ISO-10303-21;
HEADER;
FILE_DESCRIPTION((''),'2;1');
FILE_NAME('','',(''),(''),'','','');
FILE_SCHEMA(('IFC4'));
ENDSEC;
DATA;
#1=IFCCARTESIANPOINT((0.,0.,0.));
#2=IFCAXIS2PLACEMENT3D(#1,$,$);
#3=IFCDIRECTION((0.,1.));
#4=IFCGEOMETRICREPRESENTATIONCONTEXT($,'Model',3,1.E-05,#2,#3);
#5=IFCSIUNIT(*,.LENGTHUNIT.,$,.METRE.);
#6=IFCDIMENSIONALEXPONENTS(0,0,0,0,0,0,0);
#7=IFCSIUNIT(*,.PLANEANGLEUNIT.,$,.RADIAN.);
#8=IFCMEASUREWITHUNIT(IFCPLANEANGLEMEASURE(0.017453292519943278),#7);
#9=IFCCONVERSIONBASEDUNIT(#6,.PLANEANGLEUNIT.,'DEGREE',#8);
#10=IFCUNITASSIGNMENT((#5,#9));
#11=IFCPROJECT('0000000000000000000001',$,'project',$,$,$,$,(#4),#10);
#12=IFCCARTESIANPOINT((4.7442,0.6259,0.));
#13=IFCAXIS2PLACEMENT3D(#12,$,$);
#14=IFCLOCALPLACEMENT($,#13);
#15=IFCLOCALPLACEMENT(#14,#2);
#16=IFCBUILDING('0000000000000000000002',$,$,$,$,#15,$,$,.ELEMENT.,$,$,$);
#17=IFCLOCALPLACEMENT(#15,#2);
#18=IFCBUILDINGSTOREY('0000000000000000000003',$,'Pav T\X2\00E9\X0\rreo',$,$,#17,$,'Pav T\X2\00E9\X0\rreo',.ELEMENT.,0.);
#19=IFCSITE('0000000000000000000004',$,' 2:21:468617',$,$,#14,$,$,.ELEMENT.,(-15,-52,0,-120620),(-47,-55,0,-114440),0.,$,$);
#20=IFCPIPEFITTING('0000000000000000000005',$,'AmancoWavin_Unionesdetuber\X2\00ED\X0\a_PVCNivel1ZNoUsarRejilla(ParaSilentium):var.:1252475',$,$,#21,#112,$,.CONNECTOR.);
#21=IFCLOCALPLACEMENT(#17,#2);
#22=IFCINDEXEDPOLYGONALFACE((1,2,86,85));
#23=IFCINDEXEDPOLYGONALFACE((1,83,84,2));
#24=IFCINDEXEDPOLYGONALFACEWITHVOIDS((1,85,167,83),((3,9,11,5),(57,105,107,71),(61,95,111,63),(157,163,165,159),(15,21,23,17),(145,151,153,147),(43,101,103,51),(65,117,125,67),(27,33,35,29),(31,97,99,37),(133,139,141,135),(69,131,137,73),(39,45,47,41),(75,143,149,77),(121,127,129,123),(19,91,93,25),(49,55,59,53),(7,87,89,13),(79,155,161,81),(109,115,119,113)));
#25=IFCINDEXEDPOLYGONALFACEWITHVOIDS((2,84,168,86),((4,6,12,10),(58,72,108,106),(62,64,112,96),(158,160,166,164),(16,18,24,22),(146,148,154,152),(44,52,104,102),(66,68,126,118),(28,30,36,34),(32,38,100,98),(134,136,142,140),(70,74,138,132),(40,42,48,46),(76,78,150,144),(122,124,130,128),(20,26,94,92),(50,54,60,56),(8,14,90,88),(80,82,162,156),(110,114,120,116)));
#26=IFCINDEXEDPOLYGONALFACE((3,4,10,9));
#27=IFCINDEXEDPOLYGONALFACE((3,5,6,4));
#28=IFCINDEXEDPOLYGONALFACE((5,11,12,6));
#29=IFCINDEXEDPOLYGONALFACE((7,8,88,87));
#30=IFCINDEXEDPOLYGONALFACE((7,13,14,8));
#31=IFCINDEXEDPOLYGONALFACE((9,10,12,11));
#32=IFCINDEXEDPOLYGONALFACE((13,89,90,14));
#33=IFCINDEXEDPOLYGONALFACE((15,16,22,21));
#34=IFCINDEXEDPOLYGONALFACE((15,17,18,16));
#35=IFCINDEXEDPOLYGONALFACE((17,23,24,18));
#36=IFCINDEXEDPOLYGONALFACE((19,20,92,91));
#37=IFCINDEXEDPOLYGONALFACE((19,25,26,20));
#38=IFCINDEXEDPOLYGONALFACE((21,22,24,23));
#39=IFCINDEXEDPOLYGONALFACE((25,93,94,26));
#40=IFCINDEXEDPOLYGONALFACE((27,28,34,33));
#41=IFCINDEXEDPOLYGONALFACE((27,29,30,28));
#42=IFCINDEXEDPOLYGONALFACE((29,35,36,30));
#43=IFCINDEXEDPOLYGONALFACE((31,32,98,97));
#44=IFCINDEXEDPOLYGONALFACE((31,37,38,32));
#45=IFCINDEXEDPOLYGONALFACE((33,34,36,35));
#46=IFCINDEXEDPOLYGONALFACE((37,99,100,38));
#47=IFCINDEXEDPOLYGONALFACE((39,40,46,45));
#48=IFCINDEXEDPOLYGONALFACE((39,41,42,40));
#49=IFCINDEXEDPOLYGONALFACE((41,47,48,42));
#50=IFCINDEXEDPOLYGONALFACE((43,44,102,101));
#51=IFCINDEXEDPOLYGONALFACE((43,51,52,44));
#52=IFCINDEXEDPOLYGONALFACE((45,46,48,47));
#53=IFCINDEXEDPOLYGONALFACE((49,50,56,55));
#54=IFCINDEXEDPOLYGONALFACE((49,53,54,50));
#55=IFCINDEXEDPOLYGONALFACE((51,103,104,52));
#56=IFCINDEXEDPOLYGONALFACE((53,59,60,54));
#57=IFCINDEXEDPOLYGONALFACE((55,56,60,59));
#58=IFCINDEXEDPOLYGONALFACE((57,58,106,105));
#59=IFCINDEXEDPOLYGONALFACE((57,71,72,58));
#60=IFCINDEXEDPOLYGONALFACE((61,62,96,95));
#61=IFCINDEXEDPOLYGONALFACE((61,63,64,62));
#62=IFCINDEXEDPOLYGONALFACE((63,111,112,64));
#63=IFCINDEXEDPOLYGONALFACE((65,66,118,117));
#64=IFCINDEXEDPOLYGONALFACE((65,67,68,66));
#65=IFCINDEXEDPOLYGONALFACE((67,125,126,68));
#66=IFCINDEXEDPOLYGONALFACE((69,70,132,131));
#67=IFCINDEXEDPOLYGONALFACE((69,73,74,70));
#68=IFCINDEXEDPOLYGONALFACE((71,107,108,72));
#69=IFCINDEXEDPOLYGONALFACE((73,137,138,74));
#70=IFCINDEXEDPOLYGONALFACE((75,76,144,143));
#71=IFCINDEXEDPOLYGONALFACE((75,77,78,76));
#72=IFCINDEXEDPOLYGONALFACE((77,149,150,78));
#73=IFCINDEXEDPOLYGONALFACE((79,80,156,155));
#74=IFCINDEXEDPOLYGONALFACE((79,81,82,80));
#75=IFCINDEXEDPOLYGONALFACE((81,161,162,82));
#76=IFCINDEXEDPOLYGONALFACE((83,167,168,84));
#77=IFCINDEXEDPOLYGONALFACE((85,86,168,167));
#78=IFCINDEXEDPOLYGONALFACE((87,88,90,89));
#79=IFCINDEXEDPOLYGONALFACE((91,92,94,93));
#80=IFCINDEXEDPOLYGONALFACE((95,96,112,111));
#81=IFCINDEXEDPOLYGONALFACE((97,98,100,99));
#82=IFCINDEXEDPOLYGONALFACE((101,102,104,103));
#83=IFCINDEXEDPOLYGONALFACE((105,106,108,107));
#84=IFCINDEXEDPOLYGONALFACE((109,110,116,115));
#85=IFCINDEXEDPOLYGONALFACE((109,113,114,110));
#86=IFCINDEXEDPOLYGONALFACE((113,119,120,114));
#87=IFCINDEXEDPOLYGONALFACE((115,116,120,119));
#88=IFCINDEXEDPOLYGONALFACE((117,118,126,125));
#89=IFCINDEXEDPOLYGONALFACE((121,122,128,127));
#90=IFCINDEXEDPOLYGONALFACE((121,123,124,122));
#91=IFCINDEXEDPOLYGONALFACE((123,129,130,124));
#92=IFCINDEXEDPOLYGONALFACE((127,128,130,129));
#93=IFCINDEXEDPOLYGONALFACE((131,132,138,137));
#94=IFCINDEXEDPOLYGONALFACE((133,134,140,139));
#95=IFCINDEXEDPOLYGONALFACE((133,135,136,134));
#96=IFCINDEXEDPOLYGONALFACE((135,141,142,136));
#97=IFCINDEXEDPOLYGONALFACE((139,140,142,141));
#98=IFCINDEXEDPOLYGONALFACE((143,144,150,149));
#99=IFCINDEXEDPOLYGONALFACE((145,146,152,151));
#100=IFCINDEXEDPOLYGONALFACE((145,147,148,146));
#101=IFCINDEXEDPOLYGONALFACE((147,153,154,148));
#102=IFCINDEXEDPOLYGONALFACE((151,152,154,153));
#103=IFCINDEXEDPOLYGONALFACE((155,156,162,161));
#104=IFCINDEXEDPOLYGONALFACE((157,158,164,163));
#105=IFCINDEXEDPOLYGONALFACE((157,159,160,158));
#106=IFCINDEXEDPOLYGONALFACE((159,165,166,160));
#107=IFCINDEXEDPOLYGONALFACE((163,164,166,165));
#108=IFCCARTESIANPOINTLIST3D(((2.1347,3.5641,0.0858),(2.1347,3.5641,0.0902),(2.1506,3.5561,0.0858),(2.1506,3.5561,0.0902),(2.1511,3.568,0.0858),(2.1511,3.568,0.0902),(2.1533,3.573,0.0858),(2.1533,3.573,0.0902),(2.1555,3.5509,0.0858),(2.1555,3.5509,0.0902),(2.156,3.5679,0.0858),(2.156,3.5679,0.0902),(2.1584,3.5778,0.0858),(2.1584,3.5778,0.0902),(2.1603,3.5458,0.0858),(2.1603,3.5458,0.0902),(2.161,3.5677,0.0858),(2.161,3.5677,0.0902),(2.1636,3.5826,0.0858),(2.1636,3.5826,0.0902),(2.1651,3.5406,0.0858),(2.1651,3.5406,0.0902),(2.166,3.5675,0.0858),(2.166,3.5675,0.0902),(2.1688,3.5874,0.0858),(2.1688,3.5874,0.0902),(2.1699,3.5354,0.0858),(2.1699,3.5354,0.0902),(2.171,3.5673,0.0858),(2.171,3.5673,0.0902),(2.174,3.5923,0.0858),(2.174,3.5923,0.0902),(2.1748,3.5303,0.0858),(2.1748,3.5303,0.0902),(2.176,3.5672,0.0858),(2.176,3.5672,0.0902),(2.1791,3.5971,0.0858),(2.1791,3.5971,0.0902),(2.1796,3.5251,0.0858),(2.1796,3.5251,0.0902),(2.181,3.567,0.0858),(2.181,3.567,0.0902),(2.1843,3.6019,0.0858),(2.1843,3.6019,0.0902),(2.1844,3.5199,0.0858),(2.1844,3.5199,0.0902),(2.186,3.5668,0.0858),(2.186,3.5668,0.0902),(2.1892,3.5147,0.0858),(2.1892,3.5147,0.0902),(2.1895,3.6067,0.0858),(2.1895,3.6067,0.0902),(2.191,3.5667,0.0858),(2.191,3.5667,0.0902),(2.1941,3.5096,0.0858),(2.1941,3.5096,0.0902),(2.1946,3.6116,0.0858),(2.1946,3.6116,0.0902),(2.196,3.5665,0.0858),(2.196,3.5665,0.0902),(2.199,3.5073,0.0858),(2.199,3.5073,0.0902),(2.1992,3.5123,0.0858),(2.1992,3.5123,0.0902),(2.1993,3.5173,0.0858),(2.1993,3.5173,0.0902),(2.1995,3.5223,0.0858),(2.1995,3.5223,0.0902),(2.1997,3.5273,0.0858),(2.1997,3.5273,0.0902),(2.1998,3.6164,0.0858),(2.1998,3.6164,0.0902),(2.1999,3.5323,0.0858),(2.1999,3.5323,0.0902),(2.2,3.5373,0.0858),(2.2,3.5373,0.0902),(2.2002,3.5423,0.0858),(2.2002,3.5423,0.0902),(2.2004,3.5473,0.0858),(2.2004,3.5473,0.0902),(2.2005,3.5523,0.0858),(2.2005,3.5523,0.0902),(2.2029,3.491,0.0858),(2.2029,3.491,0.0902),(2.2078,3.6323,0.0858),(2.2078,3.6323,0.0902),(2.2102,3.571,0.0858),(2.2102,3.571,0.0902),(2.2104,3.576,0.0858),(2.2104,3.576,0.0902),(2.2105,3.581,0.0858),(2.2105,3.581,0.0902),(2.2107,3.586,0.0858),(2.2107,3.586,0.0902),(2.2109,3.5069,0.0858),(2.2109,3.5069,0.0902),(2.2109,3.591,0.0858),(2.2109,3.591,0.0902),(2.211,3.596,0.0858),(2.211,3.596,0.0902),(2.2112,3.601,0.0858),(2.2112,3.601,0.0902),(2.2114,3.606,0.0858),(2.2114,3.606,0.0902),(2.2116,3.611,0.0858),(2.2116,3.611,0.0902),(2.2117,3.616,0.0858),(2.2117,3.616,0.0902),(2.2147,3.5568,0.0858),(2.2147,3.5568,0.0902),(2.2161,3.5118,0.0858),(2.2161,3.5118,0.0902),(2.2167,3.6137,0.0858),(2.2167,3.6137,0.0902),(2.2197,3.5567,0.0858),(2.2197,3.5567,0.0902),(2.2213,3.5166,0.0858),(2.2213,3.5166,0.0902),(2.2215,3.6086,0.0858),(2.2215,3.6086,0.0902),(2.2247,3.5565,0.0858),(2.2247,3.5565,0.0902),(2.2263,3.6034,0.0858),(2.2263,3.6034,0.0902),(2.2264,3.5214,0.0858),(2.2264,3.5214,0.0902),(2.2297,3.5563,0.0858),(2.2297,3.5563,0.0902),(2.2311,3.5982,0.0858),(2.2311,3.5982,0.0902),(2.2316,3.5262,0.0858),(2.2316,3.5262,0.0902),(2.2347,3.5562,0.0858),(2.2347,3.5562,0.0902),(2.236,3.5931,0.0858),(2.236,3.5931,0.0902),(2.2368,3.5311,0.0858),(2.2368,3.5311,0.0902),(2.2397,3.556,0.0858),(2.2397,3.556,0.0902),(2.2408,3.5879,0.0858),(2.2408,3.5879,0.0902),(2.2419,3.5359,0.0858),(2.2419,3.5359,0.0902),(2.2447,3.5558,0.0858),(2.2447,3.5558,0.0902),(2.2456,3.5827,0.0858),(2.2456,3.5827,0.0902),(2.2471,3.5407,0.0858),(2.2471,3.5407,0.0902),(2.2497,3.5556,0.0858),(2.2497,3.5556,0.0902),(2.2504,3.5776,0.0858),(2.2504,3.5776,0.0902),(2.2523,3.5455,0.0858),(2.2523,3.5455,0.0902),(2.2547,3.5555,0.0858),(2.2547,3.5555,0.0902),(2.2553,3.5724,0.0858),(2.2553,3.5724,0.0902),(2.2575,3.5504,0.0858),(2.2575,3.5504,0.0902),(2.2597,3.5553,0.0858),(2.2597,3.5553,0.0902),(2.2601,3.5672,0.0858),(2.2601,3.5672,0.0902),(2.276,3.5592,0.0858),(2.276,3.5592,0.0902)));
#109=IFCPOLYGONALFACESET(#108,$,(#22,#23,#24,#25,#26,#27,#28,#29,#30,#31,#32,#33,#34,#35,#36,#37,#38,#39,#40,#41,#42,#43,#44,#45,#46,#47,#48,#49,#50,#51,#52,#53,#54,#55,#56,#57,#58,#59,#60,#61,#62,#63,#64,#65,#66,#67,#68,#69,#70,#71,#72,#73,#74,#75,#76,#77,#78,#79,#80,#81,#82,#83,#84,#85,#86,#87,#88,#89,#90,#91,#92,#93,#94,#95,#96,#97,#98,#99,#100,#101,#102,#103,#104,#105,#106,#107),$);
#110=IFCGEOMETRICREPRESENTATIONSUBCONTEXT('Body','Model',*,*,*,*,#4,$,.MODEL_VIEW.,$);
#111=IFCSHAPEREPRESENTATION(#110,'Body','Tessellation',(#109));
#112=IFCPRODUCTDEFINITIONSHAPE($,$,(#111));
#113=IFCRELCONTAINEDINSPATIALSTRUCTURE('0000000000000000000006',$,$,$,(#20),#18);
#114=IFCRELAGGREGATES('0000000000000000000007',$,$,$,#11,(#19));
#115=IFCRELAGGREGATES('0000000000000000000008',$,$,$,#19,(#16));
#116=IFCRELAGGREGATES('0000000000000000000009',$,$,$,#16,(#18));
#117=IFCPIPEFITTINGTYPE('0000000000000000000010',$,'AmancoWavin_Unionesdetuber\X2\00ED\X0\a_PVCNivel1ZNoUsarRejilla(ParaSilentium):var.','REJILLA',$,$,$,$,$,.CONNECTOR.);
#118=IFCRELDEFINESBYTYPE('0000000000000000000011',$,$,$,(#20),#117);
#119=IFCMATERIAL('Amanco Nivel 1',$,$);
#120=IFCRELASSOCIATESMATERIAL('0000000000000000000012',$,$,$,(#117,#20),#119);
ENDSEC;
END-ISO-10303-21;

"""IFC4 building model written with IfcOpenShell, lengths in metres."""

from ifc_helpers import new_model, entity, si_unit, converted_unit, direction, frame, origin, place, context, subcontext, project, spatial, indexed_curve, outline, extrude, source, transform, mapped, material, type_object, type_shapes, element, save


model = new_model("IFC4")

# Units and contexts
model_context = context("Model", 3, precision=1e-05, world=origin(), true_north=direction((0.0, 1.0)))
body_context = subcontext(model_context, "Body", "Model", "MODEL_VIEW")
ifc_project = project(units=[si_unit("LENGTHUNIT", "METRE"), converted_unit("PLANEANGLEUNIT", "DEGREE", entity("IfcPlaneAngleMeasure", 0.017453292519943278), si_unit("PLANEANGLEUNIT", "RADIAN"), dimensions=[0, 0, 0, 0, 0, 0, 0])], contexts=[model_context])

# Site, building, storey
site_placement = place(None, frame((4.7442, 0.6259, 0.0)))
site = spatial("IfcSite", under=ifc_project, at=site_placement, Name=" 2:21:468617", CompositionType="ELEMENT", RefLatitude=(-15, -52, 0, -120620), RefLongitude=(-47, -55, 0, -114440), RefElevation=0.0)
building_placement = place(site_placement, origin())
building = spatial("IfcBuilding", under=site, at=building_placement, CompositionType="ELEMENT")
storey_placement = place(building_placement, origin())
storey = spatial("IfcBuildingStorey", under=building, at=storey_placement, Name="Pav Térreo", LongName="Pav Térreo", CompositionType="ELEMENT", Elevation=0.0)

# Pipe fitting
ifc_material = material(Name="Amanco Nivel 1")
pipe_fitting_type = type_object("IfcPipeFittingType", Name="AmancoWavin_Unionesdetubería_PVCNivel1ZNoUsarRejilla(ParaSilentium):var.", Description="REJILLA", PredefinedType="CONNECTOR", material=ifc_material)
shared_shape = source(origin(), body_context, "Body", "SweptSolid", [
    extrude(outline(indexed_curve([(-0.05, -0.05), (0.05, -0.05), (0.05, 0.05), (-0.05, 0.05), (-0.05, -0.05)], self_intersect=False), holes=[indexed_curve([(0.0417, 0.0354), (0.0382, 0.0318), (0.0262, 0.0438), (0.0333, 0.0438), (0.0417, 0.0354)], self_intersect=False), indexed_curve([(0.0346, 0.0283), (0.0311, 0.0247), (0.0121, 0.0438), (0.0191, 0.0438), (0.0346, 0.0283)], self_intersect=False), indexed_curve([(0.0276, 0.0212), (0.024, 0.0177), (-0.0021, 0.0438), (0.005, 0.0438), (0.0276, 0.0212)], self_intersect=False), indexed_curve([(0.0205, 0.0141), (0.017, 0.0106), (-0.0162, 0.0438), (-0.0092, 0.0438), (0.0205, 0.0141)], self_intersect=False), indexed_curve([(0.0134, 0.0071), (0.0099, 0.0035), (-0.0304, 0.0438), (-0.0233, 0.0438), (0.0134, 0.0071)], self_intersect=False), indexed_curve([(-0.0354, 0.0417), (-0.0318, 0.0382), (-0.0438, 0.0262), (-0.0438, 0.0333), (-0.0354, 0.0417)], self_intersect=False), indexed_curve([(-0.0283, 0.0346), (-0.0247, 0.0311), (-0.0438, 0.0121), (-0.0438, 0.0191), (-0.0283, 0.0346)], self_intersect=False), indexed_curve([(-0.0212, 0.0276), (-0.0177, 0.024), (-0.0438, -0.0021), (-0.0438, 0.005), (-0.0212, 0.0276)], self_intersect=False), indexed_curve([(-0.0141, 0.0205), (-0.0106, 0.017), (-0.0438, -0.0162), (-0.0438, -0.0092), (-0.0141, 0.0205)], self_intersect=False), indexed_curve([(-0.0071, 0.0134), (-0.0035, 0.0099), (-0.0438, -0.0304), (-0.0438, -0.0233), (-0.0071, 0.0134)], self_intersect=False), indexed_curve([(-0.0417, -0.0354), (-0.0382, -0.0318), (-0.0262, -0.0438), (-0.0333, -0.0438), (-0.0417, -0.0354)], self_intersect=False), indexed_curve([(-0.0346, -0.0283), (-0.0311, -0.0247), (-0.0121, -0.0438), (-0.0191, -0.0438), (-0.0346, -0.0283)], self_intersect=False), indexed_curve([(-0.0276, -0.0212), (-0.024, -0.0177), (0.0021, -0.0438), (-0.005, -0.0438), (-0.0276, -0.0212)], self_intersect=False), indexed_curve([(-0.0205, -0.0141), (-0.017, -0.0106), (0.0162, -0.0438), (0.0092, -0.0438), (-0.0205, -0.0141)], self_intersect=False), indexed_curve([(-0.0134, -0.0071), (-0.0099, -0.0035), (0.0304, -0.0438), (0.0233, -0.0438), (-0.0134, -0.0071)], self_intersect=False), indexed_curve([(0.0354, -0.0417), (0.0318, -0.0382), (0.0438, -0.0262), (0.0438, -0.0333), (0.0354, -0.0417)], self_intersect=False), indexed_curve([(0.0283, -0.0346), (0.0247, -0.0311), (0.0438, -0.0121), (0.0438, -0.0191), (0.0283, -0.0346)], self_intersect=False), indexed_curve([(0.0212, -0.0276), (0.0177, -0.024), (0.0438, 0.0021), (0.0438, -0.005), (0.0212, -0.0276)], self_intersect=False), indexed_curve([(0.0141, -0.0205), (0.0106, -0.017), (0.0438, 0.0162), (0.0438, 0.0092), (0.0141, -0.0205)], self_intersect=False), indexed_curve([(0.0071, -0.0134), (0.0035, -0.0099), (0.0438, 0.0304), (0.0438, 0.0233), (0.0071, -0.0134)], self_intersect=False)]), frame((-0.0692, 0.0, -0.0042), z_axis=(0.0, 0.0, 1.0), x_axis=(-1.0, 0.0, 0.0)), (0.0, 0.0, 1.0), 0.0044),
])
type_shapes(pipe_fitting_type, [shared_shape])
pipe_fitting_placement = place(storey_placement, frame((2.256, 3.6089, 0.09), z_axis=(0.0, 0.0, 1.0), x_axis=(0.730915, 0.682468, 0.0)))
element("IfcPipeFitting", 1, at=pipe_fitting_placement, inside=storey, type_object=pipe_fitting_type, material=ifc_material, Name="AmancoWavin_Unionesdetubería_PVCNivel1ZNoUsarRejilla(ParaSilentium):var.:1252475", PredefinedType="CONNECTOR", context=body_context, shape_type="MappedRepresentation", body=[
    mapped(shared_shape, transform((0.0, 0.0, 0.0), scale=1.0)),
])

save(model, "model.ifc")
